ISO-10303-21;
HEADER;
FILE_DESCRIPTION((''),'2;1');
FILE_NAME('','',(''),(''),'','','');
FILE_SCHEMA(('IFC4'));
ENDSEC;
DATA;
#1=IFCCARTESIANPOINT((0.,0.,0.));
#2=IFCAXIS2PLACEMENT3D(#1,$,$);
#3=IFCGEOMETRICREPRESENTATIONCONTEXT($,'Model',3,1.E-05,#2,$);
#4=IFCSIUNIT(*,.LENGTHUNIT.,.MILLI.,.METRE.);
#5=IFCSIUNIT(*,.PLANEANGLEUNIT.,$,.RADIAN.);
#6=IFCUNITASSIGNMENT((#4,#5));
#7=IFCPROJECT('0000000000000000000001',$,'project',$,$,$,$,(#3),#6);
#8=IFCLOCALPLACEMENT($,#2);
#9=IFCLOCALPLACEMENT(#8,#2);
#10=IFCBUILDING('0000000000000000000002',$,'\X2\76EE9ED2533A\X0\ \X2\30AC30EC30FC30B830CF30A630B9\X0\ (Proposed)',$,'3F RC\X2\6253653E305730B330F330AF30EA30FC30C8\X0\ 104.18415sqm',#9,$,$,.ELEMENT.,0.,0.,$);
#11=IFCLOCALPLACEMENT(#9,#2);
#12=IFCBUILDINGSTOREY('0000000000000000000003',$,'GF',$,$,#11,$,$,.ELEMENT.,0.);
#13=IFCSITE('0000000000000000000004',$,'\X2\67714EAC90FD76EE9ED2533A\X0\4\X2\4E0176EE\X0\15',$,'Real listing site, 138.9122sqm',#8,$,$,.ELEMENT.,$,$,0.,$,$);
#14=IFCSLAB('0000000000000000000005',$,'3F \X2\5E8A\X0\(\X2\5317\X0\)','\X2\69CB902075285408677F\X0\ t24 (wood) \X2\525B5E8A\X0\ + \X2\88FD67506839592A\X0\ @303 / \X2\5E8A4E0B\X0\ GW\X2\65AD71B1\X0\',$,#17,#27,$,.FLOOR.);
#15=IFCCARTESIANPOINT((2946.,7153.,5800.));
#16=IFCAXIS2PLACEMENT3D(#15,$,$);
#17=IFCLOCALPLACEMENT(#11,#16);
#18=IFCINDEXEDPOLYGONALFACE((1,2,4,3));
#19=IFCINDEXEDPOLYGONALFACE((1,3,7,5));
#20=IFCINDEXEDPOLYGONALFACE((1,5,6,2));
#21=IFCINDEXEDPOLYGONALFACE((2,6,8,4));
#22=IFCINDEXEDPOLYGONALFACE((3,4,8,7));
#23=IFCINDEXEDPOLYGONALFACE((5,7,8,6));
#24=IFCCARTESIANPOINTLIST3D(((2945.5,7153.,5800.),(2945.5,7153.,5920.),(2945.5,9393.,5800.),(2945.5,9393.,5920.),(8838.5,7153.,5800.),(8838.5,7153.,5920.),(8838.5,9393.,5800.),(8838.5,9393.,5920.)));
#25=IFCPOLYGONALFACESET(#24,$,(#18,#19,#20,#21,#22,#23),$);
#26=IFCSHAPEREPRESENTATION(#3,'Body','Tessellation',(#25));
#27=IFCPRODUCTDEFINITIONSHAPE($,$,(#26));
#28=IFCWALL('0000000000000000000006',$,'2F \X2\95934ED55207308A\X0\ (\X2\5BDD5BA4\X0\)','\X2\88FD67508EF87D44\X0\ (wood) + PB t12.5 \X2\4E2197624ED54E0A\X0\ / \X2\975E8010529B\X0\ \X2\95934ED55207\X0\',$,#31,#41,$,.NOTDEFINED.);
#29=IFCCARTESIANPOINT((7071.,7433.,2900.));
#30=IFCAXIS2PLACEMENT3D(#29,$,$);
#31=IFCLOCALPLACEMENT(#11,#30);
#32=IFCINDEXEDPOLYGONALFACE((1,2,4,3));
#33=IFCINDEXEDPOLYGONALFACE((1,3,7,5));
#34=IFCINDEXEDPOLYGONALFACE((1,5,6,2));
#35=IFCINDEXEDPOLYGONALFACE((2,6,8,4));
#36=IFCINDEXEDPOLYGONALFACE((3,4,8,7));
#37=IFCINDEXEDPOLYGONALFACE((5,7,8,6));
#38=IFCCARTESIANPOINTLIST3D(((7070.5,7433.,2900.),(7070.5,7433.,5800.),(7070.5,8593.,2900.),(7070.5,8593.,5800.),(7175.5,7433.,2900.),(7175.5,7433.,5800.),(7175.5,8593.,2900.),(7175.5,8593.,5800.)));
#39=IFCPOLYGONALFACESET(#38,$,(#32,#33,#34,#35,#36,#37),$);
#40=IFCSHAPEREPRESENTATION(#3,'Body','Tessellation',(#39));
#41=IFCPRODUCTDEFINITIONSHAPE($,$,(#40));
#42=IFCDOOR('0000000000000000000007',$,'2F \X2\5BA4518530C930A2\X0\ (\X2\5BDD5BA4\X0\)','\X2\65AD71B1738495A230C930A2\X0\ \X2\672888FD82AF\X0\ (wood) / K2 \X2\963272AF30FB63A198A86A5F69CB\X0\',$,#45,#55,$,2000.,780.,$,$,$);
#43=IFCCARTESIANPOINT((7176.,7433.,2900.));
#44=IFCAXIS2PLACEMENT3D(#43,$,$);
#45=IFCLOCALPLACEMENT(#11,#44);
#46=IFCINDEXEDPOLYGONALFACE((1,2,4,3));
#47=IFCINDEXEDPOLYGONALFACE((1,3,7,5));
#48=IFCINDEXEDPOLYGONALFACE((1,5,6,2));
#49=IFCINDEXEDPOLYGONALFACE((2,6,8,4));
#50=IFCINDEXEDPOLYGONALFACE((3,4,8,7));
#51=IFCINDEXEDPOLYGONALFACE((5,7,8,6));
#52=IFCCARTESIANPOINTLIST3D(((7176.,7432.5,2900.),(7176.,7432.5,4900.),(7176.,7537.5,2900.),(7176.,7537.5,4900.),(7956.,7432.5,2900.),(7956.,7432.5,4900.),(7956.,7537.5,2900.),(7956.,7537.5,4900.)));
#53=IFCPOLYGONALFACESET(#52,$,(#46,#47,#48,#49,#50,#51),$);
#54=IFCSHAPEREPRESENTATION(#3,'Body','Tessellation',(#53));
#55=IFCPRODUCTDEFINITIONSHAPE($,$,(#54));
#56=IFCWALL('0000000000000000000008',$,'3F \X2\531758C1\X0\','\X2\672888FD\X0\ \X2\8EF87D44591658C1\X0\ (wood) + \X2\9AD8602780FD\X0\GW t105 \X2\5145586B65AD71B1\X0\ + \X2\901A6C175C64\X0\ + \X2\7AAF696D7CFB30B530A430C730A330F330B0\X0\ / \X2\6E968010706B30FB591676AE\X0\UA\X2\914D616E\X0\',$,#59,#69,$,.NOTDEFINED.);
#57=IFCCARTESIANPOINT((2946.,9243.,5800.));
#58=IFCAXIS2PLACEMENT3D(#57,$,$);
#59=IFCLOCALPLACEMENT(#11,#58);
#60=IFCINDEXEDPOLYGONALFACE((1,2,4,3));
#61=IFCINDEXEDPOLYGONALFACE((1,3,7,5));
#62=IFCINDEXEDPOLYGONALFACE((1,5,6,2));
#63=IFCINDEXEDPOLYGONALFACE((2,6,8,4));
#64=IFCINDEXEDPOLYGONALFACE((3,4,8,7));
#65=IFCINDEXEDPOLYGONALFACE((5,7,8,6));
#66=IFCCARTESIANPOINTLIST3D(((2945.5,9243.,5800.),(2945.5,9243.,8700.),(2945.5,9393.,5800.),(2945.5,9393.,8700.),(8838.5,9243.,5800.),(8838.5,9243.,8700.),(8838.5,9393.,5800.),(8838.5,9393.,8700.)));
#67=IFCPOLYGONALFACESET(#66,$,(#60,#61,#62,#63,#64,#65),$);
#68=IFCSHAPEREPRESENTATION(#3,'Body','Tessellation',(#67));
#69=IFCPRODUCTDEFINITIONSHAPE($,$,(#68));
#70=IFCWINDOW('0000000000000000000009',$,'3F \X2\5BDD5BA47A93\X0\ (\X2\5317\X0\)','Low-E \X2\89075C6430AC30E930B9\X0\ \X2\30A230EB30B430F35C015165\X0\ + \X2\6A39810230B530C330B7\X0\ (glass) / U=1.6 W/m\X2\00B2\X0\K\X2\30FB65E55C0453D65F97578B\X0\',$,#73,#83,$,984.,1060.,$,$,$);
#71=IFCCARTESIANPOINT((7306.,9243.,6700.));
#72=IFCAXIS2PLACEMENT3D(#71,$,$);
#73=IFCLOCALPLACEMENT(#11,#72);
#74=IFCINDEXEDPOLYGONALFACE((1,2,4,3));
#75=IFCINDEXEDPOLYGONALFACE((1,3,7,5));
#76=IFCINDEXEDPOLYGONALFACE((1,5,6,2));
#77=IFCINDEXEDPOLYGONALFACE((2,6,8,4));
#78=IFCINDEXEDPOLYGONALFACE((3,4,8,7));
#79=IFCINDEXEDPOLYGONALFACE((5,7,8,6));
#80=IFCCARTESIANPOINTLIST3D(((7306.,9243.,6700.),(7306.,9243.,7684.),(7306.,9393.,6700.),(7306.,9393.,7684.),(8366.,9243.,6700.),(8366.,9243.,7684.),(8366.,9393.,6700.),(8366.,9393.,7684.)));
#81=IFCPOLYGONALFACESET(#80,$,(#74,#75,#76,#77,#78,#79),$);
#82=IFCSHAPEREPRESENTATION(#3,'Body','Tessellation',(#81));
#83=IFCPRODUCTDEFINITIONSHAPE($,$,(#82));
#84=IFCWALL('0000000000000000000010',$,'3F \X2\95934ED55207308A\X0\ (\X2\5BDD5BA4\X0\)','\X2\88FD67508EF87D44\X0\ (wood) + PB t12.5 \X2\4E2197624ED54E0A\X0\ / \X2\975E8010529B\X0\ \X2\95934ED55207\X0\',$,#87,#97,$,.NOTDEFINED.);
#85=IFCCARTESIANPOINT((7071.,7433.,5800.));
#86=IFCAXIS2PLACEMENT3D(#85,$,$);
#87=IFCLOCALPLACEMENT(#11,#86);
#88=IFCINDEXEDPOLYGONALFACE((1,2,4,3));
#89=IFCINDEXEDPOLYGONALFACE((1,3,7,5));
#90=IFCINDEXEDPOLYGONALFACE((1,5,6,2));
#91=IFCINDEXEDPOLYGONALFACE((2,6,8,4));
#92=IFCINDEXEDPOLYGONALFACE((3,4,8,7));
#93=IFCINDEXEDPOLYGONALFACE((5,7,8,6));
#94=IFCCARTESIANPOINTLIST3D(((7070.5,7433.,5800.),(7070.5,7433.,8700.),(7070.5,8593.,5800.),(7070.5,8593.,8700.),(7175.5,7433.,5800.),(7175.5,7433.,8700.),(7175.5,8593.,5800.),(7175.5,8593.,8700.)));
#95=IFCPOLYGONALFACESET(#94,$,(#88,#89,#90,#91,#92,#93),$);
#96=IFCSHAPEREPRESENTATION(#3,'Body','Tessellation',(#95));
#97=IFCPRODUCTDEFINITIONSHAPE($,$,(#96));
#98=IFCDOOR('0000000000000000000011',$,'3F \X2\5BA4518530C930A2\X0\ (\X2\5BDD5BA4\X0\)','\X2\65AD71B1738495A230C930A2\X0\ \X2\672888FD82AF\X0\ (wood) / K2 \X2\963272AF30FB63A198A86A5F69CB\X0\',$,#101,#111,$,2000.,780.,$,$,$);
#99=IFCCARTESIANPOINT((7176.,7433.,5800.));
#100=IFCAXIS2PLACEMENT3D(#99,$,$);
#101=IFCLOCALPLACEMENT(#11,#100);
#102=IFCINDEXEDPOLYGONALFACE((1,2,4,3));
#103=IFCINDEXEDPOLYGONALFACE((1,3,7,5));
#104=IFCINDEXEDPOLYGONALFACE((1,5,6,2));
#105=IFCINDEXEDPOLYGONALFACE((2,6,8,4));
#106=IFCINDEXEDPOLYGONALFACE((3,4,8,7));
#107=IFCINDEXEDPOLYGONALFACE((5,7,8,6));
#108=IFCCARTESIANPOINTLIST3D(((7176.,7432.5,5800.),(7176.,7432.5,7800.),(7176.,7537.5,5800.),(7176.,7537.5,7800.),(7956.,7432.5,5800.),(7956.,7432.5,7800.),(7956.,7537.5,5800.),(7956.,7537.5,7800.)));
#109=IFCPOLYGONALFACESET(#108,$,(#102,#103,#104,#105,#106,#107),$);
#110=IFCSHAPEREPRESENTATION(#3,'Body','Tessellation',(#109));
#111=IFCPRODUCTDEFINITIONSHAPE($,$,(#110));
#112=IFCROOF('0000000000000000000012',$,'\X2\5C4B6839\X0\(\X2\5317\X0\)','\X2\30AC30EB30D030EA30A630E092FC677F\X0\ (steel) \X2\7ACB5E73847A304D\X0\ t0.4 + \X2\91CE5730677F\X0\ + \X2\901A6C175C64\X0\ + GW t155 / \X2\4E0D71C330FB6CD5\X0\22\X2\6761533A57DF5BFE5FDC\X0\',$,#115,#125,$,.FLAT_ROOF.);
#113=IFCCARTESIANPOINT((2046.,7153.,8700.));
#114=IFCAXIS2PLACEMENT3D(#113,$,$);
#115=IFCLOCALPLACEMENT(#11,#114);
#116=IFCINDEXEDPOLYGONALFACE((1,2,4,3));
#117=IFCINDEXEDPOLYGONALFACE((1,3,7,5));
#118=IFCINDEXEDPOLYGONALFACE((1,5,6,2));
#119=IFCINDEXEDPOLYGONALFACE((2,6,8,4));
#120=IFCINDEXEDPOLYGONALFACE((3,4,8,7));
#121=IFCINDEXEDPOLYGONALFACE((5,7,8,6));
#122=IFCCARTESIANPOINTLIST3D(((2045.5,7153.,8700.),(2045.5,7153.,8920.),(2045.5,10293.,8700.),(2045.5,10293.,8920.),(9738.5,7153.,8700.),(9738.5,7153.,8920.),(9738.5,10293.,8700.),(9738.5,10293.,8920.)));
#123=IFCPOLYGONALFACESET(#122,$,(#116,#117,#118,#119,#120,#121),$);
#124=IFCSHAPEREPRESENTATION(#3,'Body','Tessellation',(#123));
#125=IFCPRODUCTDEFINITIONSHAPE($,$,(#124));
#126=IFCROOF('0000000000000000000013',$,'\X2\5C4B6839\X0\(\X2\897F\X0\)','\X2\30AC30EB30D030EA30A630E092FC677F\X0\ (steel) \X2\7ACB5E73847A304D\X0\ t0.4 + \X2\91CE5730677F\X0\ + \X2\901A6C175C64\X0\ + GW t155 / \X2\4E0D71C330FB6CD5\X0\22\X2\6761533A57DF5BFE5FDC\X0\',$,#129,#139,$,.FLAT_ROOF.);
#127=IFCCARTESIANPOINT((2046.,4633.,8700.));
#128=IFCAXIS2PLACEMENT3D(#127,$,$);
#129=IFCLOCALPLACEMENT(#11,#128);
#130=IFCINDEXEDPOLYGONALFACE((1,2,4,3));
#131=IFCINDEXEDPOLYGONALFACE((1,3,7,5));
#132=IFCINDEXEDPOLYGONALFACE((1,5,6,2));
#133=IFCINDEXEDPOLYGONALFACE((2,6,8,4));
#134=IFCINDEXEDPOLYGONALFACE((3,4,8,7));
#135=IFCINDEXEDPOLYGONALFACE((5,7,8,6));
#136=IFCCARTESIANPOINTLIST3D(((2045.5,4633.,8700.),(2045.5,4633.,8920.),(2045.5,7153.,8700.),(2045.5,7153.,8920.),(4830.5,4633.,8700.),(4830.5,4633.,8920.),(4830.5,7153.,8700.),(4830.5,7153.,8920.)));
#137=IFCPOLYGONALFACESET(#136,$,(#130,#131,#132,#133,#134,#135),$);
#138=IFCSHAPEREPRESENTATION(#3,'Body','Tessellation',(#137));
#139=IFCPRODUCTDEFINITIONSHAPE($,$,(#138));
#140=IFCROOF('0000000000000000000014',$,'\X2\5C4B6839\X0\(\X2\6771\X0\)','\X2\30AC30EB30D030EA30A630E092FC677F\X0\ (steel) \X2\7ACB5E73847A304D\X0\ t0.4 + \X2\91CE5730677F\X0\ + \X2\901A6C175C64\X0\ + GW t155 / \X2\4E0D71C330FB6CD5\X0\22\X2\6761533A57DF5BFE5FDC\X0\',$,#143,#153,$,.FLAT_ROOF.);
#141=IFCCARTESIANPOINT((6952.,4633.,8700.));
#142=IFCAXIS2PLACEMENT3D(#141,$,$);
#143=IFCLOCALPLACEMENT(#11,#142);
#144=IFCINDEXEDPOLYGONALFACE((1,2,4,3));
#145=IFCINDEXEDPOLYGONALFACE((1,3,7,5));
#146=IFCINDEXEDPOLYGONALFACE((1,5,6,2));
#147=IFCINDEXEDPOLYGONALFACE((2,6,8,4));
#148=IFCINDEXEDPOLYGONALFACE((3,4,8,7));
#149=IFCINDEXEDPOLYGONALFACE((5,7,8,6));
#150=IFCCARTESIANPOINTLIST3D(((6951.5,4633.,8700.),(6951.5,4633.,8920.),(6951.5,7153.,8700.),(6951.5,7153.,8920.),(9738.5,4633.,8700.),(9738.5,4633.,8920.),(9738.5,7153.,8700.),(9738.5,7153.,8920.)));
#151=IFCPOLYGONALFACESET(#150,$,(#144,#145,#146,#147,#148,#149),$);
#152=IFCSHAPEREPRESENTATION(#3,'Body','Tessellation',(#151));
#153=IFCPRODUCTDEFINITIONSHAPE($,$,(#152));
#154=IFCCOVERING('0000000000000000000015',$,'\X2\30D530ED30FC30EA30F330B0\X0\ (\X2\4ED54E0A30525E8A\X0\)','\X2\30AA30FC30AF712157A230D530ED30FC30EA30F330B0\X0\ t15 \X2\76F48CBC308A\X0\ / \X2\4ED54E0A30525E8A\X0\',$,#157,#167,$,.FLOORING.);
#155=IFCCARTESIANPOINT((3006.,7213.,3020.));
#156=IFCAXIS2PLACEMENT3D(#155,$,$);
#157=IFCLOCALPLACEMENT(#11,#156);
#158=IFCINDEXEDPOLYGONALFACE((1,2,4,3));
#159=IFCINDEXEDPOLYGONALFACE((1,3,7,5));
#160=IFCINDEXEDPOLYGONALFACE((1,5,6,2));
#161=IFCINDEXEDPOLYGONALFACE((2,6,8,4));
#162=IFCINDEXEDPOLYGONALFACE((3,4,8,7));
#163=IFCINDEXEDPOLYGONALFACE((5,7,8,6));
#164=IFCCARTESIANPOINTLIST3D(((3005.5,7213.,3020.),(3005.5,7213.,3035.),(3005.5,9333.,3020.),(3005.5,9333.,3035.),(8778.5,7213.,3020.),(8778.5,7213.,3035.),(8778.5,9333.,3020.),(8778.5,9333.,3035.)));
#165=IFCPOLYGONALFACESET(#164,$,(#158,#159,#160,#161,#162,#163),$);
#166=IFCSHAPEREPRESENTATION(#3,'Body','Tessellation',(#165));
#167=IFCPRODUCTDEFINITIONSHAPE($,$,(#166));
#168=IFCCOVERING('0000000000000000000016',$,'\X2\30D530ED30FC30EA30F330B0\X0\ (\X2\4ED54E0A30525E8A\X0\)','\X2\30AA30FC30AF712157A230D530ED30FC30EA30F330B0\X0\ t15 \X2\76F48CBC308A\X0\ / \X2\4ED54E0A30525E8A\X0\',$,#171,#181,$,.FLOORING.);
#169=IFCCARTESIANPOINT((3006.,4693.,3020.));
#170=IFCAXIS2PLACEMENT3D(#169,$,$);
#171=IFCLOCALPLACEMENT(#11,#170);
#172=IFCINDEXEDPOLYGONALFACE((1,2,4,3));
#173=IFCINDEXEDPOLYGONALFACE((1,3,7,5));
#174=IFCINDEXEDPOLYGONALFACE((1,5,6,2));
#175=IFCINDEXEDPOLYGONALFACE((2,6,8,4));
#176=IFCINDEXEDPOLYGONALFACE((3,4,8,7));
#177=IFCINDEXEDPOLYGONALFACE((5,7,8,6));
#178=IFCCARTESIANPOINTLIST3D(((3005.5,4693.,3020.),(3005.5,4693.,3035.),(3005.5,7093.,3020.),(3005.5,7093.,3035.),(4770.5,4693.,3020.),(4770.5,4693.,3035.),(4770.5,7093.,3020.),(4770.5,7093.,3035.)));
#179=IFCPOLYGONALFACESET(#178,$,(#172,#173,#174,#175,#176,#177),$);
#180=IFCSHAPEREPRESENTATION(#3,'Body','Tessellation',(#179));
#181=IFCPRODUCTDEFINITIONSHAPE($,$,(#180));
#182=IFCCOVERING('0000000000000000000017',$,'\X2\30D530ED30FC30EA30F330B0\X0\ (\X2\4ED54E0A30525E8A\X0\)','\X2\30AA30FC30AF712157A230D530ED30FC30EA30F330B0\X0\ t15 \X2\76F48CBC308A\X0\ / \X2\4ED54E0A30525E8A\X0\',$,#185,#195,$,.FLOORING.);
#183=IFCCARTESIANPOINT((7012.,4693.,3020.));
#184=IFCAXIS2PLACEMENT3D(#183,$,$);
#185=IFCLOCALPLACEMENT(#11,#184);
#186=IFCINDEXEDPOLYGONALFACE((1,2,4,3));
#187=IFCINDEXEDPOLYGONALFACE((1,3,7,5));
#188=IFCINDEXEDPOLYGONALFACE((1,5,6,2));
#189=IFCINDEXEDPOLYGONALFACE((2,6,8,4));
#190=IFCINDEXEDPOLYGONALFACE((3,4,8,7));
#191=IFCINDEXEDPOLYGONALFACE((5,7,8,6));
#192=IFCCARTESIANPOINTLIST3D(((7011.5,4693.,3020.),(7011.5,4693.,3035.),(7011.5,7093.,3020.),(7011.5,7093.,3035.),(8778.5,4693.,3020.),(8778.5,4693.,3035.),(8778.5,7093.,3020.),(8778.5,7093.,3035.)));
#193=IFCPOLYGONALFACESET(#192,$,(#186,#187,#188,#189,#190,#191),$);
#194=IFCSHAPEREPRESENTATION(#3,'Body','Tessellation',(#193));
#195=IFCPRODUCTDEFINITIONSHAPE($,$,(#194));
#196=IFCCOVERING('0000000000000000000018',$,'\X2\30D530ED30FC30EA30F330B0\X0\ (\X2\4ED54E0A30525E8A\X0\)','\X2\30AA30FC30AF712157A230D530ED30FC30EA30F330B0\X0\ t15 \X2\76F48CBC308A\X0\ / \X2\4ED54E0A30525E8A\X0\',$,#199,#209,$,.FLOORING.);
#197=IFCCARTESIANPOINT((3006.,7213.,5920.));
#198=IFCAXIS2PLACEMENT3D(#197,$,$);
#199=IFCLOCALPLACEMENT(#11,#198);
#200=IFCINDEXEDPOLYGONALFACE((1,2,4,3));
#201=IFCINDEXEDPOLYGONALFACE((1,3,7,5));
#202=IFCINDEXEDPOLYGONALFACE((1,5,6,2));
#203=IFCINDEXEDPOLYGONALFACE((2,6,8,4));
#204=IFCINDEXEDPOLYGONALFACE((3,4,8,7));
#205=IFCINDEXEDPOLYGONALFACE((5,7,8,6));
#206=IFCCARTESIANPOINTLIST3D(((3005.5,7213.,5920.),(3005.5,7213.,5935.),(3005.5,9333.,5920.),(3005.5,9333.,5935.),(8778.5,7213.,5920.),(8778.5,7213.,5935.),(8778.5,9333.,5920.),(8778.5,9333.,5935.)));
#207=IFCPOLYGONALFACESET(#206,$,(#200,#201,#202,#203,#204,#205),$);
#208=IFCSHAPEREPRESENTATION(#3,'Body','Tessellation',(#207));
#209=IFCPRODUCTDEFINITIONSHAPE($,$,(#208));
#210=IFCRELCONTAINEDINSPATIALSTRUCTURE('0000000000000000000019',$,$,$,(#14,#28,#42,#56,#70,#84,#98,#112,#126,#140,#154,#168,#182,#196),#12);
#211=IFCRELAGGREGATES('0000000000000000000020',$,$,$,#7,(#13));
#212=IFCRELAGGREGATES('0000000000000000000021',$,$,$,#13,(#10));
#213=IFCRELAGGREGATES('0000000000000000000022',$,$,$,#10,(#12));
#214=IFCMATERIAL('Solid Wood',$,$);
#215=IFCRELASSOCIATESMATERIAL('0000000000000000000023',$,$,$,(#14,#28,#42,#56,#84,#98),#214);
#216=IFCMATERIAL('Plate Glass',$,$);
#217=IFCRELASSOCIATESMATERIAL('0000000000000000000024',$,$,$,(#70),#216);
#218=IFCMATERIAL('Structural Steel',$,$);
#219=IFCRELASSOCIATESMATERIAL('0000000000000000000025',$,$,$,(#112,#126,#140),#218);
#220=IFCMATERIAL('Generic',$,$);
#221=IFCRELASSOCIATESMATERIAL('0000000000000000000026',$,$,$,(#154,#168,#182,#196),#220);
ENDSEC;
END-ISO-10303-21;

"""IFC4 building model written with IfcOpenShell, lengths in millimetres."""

from ifc_helpers import new_model, si_unit, frame, frame_2d, origin, place, context, project, spatial, rectangle, extrude, material, element, fill, save


model = new_model("IFC4")

# Units and contexts
model_context = context("Model", 3, precision=1e-05, world=origin())
ifc_project = project(units=[si_unit("LENGTHUNIT", "METRE", prefix="MILLI"), si_unit("PLANEANGLEUNIT", "RADIAN")], contexts=[model_context])

# Site, building, storey
site_placement = place(None, origin())
site = spatial("IfcSite", under=ifc_project, at=site_placement, Name="東京都目黒区4丁目15", ObjectType="Real listing site, 138.9122sqm", CompositionType="ELEMENT", RefElevation=0.0)
building_placement = place(site_placement, origin())
building = spatial("IfcBuilding", under=site, at=building_placement, Name="目黒区 ガレージハウス (Proposed)", ObjectType="3F RC打放しコンクリート 104.18415sqm", CompositionType="ELEMENT", ElevationOfRefHeight=0.0, ElevationOfTerrain=0.0)
storey_placement = place(building_placement, origin())
storey = spatial("IfcBuildingStorey", under=building, at=storey_placement, Name="GF", CompositionType="ELEMENT", Elevation=0.0)

# Slab
ifc_material_1 = material(Name="Solid Wood")
slab_placement = place(storey_placement, frame((2946.0, 7153.0, 5800.0)))
element("IfcSlab", 1, at=slab_placement, inside=storey, material=ifc_material_1, Name="3F 床(北)", Description="構造用合板 t24 (wood) 剛床 + 製材根太 @303 / 床下 GW断熱", PredefinedType="FLOOR", context=model_context, shape_type="SweptSolid", body=[
    extrude(rectangle(XDim=5893.0, YDim=2240.0, at=frame_2d((2946.0, 1120.0))), frame((2946.0, 7153.0, 5800.0)), (0.0, 0.0, 1.0), 120.0),
])

# Wall
wall_1_placement = place(storey_placement, frame((7071.0, 7433.0, 2900.0)))
element("IfcWall", 2, at=wall_1_placement, inside=storey, material=ifc_material_1, Name="2F 間仕切り (寝室)", Description="製材軸組 (wood) + PB t12.5 両面仕上 / 非耐力 間仕切", PredefinedType="NOTDEFINED", context=model_context, shape_type="SweptSolid", body=[
    extrude(rectangle(XDim=105.0, YDim=1160.0, at=frame_2d((52.0, 580.0))), frame((7071.0, 7433.0, 2900.0)), (0.0, 0.0, 1.0), 2900.0),
])

# Door
door_1_placement = place(storey_placement, frame((7176.0, 7433.0, 2900.0)))
element("IfcDoor", 3, at=door_1_placement, inside=storey, material=ifc_material_1, Name="2F 室内ドア (寝室)", Description="断熱玄関ドア 木製芯 (wood) / K2 防犯・採風機構", OverallHeight=2000.0, OverallWidth=780.0, context=model_context, shape_type="SweptSolid", body=[
    extrude(rectangle(XDim=780.0, YDim=105.0, at=frame_2d((390.0, 52.0))), frame((7176.0, 7433.0, 2900.0)), (0.0, 0.0, 1.0), 2000.0),
])

# Wall, opening, window
wall_2_placement = place(storey_placement, frame((2946.0, 9243.0, 5800.0)))
wall_2 = element("IfcWall", 4, at=wall_2_placement, inside=storey, material=ifc_material_1, Name="3F 北壁", Description="木製 軸組外壁 (wood) + 高性能GW t105 充填断熱 + 通気層 + 窯業系サイディング / 準耐火・外皮UA配慮", PredefinedType="NOTDEFINED", context=model_context, shape_type="SweptSolid", body=[
    extrude(rectangle(XDim=5893.0, YDim=150.0, at=frame_2d((2946.0, 75.0))), frame((2946.0, 9243.0, 5800.0)), (0.0, 0.0, 1.0), 2900.0),
])
opening_1_placement = place(storey_placement, frame((7306.0, 9243.0, 6700.0)))
opening_1 = element("IfcOpeningElement", 5, at=opening_1_placement, cuts=wall_2, PredefinedType="NOTDEFINED", context=model_context, shape_type="SweptSolid", body=[
    extrude(rectangle(XDim=1060.0, YDim=150.0, at=frame_2d((530.0, 75.0))), frame((7306.0, 9243.0, 6700.0)), (0.0, 0.0, 1.0), 984.0),
])
ifc_material_2 = material(Name="Plate Glass")
window_1_placement = place(storey_placement, frame((7306.0, 9243.0, 6700.0)))
window_1 = element("IfcWindow", 6, at=window_1_placement, inside=storey, material=ifc_material_2, Name="3F 寝室窓 (北)", Description="Low-E 複層ガラス アルゴン封入 + 樹脂サッシ (glass) / U=1.6 W/m²K・日射取得型", OverallHeight=984.0, OverallWidth=1060.0, context=model_context, shape_type="SweptSolid", body=[
    extrude(rectangle(XDim=1060.0, YDim=150.0, at=frame_2d((530.0, 75.0))), frame((7306.0, 9243.0, 6700.0)), (0.0, 0.0, 1.0), 984.0),
])
fill(opening_1, window_1)

# Wall
wall_3_placement = place(storey_placement, frame((7071.0, 7433.0, 5800.0)))
element("IfcWall", 7, at=wall_3_placement, inside=storey, material=ifc_material_1, Name="3F 間仕切り (寝室)", Description="製材軸組 (wood) + PB t12.5 両面仕上 / 非耐力 間仕切", PredefinedType="NOTDEFINED", context=model_context, shape_type="SweptSolid", body=[
    extrude(rectangle(XDim=105.0, YDim=1160.0, at=frame_2d((52.0, 580.0))), frame((7071.0, 7433.0, 5800.0)), (0.0, 0.0, 1.0), 2900.0),
])

# Door
door_2_placement = place(storey_placement, frame((7176.0, 7433.0, 5800.0)))
element("IfcDoor", 8, at=door_2_placement, inside=storey, material=ifc_material_1, Name="3F 室内ドア (寝室)", Description="断熱玄関ドア 木製芯 (wood) / K2 防犯・採風機構", OverallHeight=2000.0, OverallWidth=780.0, context=model_context, shape_type="SweptSolid", body=[
    extrude(rectangle(XDim=780.0, YDim=105.0, at=frame_2d((390.0, 52.0))), frame((7176.0, 7433.0, 5800.0)), (0.0, 0.0, 1.0), 2000.0),
])

# Roofs
ifc_material_3 = material(Name="Structural Steel")
for number, where, name in (
    (9, (2046.0, 7153.0, 8700.0), "屋根(北)"),
):
    element("IfcRoof", number, at=place(storey_placement, frame(where)), inside=storey, material=ifc_material_3, Name=name, Description="ガルバリウム鋼板 (steel) 立平葺き t0.4 + 野地板 + 通気層 + GW t155 / 不燃・法22条区域対応", PredefinedType="FLAT_ROOF", context=model_context, shape_type="SweptSolid", body=[
        extrude(rectangle(XDim=7693.0, YDim=3140.0, at=frame_2d((3846.0, 1570.0))), frame((2046.0, 7153.0, 8700.0)), (0.0, 0.0, 1.0), 220.0),
    ])
roof_1_placement = place(storey_placement, frame((2046.0, 4633.0, 8700.0)))
element("IfcRoof", 10, at=roof_1_placement, inside=storey, material=ifc_material_3, Name="屋根(西)", Description="ガルバリウム鋼板 (steel) 立平葺き t0.4 + 野地板 + 通気層 + GW t155 / 不燃・法22条区域対応", PredefinedType="FLAT_ROOF", context=model_context, shape_type="SweptSolid", body=[
    extrude(rectangle(XDim=2785.0, YDim=2520.0, at=frame_2d((1392.0, 1260.0))), frame((2046.0, 4633.0, 8700.0)), (0.0, 0.0, 1.0), 220.0),
])
roof_2_placement = place(storey_placement, frame((6952.0, 4633.0, 8700.0)))
element("IfcRoof", 11, at=roof_2_placement, inside=storey, material=ifc_material_3, Name="屋根(東)", Description="ガルバリウム鋼板 (steel) 立平葺き t0.4 + 野地板 + 通気層 + GW t155 / 不燃・法22条区域対応", PredefinedType="FLAT_ROOF", context=model_context, shape_type="SweptSolid", body=[
    extrude(rectangle(XDim=2787.0, YDim=2520.0, at=frame_2d((1393.0, 1260.0))), frame((6952.0, 4633.0, 8700.0)), (0.0, 0.0, 1.0), 220.0),
])

# Coverings
ifc_material_4 = material(Name="Generic")
covering_1_placement = place(storey_placement, frame((3006.0, 7213.0, 3020.0)))
element("IfcCovering", 12, at=covering_1_placement, inside=storey, material=ifc_material_4, Name="フローリング (仕上げ床)", Description="オーク無垢フローリング t15 直貼り / 仕上げ床", PredefinedType="FLOORING", context=model_context, shape_type="SweptSolid", body=[
    extrude(rectangle(XDim=5773.0, YDim=2120.0, at=frame_2d((2886.0, 1060.0))), frame((3006.0, 7213.0, 3020.0)), (0.0, 0.0, 1.0), 15.0),
])
covering_2_placement = place(storey_placement, frame((3006.0, 4693.0, 3020.0)))
element("IfcCovering", 13, at=covering_2_placement, inside=storey, material=ifc_material_4, Name="フローリング (仕上げ床)", Description="オーク無垢フローリング t15 直貼り / 仕上げ床", PredefinedType="FLOORING", context=model_context, shape_type="SweptSolid", body=[
    extrude(rectangle(XDim=1765.0, YDim=2400.0, at=frame_2d((882.0, 1200.0))), frame((3006.0, 4693.0, 3020.0)), (0.0, 0.0, 1.0), 15.0),
])
covering_3_placement = place(storey_placement, frame((7012.0, 4693.0, 3020.0)))
element("IfcCovering", 14, at=covering_3_placement, inside=storey, material=ifc_material_4, Name="フローリング (仕上げ床)", Description="オーク無垢フローリング t15 直貼り / 仕上げ床", PredefinedType="FLOORING", context=model_context, shape_type="SweptSolid", body=[
    extrude(rectangle(XDim=1767.0, YDim=2400.0, at=frame_2d((883.0, 1200.0))), frame((7012.0, 4693.0, 3020.0)), (0.0, 0.0, 1.0), 15.0),
])
covering_4_placement = place(storey_placement, frame((3006.0, 7213.0, 5920.0)))
element("IfcCovering", 15, at=covering_4_placement, inside=storey, material=ifc_material_4, Name="フローリング (仕上げ床)", Description="オーク無垢フローリング t15 直貼り / 仕上げ床", PredefinedType="FLOORING", context=model_context, shape_type="SweptSolid", body=[
    extrude(rectangle(XDim=5773.0, YDim=2120.0, at=frame_2d((2886.0, 1060.0))), frame((3006.0, 7213.0, 5920.0)), (0.0, 0.0, 1.0), 15.0),
])

save(model, "model.ifc")
